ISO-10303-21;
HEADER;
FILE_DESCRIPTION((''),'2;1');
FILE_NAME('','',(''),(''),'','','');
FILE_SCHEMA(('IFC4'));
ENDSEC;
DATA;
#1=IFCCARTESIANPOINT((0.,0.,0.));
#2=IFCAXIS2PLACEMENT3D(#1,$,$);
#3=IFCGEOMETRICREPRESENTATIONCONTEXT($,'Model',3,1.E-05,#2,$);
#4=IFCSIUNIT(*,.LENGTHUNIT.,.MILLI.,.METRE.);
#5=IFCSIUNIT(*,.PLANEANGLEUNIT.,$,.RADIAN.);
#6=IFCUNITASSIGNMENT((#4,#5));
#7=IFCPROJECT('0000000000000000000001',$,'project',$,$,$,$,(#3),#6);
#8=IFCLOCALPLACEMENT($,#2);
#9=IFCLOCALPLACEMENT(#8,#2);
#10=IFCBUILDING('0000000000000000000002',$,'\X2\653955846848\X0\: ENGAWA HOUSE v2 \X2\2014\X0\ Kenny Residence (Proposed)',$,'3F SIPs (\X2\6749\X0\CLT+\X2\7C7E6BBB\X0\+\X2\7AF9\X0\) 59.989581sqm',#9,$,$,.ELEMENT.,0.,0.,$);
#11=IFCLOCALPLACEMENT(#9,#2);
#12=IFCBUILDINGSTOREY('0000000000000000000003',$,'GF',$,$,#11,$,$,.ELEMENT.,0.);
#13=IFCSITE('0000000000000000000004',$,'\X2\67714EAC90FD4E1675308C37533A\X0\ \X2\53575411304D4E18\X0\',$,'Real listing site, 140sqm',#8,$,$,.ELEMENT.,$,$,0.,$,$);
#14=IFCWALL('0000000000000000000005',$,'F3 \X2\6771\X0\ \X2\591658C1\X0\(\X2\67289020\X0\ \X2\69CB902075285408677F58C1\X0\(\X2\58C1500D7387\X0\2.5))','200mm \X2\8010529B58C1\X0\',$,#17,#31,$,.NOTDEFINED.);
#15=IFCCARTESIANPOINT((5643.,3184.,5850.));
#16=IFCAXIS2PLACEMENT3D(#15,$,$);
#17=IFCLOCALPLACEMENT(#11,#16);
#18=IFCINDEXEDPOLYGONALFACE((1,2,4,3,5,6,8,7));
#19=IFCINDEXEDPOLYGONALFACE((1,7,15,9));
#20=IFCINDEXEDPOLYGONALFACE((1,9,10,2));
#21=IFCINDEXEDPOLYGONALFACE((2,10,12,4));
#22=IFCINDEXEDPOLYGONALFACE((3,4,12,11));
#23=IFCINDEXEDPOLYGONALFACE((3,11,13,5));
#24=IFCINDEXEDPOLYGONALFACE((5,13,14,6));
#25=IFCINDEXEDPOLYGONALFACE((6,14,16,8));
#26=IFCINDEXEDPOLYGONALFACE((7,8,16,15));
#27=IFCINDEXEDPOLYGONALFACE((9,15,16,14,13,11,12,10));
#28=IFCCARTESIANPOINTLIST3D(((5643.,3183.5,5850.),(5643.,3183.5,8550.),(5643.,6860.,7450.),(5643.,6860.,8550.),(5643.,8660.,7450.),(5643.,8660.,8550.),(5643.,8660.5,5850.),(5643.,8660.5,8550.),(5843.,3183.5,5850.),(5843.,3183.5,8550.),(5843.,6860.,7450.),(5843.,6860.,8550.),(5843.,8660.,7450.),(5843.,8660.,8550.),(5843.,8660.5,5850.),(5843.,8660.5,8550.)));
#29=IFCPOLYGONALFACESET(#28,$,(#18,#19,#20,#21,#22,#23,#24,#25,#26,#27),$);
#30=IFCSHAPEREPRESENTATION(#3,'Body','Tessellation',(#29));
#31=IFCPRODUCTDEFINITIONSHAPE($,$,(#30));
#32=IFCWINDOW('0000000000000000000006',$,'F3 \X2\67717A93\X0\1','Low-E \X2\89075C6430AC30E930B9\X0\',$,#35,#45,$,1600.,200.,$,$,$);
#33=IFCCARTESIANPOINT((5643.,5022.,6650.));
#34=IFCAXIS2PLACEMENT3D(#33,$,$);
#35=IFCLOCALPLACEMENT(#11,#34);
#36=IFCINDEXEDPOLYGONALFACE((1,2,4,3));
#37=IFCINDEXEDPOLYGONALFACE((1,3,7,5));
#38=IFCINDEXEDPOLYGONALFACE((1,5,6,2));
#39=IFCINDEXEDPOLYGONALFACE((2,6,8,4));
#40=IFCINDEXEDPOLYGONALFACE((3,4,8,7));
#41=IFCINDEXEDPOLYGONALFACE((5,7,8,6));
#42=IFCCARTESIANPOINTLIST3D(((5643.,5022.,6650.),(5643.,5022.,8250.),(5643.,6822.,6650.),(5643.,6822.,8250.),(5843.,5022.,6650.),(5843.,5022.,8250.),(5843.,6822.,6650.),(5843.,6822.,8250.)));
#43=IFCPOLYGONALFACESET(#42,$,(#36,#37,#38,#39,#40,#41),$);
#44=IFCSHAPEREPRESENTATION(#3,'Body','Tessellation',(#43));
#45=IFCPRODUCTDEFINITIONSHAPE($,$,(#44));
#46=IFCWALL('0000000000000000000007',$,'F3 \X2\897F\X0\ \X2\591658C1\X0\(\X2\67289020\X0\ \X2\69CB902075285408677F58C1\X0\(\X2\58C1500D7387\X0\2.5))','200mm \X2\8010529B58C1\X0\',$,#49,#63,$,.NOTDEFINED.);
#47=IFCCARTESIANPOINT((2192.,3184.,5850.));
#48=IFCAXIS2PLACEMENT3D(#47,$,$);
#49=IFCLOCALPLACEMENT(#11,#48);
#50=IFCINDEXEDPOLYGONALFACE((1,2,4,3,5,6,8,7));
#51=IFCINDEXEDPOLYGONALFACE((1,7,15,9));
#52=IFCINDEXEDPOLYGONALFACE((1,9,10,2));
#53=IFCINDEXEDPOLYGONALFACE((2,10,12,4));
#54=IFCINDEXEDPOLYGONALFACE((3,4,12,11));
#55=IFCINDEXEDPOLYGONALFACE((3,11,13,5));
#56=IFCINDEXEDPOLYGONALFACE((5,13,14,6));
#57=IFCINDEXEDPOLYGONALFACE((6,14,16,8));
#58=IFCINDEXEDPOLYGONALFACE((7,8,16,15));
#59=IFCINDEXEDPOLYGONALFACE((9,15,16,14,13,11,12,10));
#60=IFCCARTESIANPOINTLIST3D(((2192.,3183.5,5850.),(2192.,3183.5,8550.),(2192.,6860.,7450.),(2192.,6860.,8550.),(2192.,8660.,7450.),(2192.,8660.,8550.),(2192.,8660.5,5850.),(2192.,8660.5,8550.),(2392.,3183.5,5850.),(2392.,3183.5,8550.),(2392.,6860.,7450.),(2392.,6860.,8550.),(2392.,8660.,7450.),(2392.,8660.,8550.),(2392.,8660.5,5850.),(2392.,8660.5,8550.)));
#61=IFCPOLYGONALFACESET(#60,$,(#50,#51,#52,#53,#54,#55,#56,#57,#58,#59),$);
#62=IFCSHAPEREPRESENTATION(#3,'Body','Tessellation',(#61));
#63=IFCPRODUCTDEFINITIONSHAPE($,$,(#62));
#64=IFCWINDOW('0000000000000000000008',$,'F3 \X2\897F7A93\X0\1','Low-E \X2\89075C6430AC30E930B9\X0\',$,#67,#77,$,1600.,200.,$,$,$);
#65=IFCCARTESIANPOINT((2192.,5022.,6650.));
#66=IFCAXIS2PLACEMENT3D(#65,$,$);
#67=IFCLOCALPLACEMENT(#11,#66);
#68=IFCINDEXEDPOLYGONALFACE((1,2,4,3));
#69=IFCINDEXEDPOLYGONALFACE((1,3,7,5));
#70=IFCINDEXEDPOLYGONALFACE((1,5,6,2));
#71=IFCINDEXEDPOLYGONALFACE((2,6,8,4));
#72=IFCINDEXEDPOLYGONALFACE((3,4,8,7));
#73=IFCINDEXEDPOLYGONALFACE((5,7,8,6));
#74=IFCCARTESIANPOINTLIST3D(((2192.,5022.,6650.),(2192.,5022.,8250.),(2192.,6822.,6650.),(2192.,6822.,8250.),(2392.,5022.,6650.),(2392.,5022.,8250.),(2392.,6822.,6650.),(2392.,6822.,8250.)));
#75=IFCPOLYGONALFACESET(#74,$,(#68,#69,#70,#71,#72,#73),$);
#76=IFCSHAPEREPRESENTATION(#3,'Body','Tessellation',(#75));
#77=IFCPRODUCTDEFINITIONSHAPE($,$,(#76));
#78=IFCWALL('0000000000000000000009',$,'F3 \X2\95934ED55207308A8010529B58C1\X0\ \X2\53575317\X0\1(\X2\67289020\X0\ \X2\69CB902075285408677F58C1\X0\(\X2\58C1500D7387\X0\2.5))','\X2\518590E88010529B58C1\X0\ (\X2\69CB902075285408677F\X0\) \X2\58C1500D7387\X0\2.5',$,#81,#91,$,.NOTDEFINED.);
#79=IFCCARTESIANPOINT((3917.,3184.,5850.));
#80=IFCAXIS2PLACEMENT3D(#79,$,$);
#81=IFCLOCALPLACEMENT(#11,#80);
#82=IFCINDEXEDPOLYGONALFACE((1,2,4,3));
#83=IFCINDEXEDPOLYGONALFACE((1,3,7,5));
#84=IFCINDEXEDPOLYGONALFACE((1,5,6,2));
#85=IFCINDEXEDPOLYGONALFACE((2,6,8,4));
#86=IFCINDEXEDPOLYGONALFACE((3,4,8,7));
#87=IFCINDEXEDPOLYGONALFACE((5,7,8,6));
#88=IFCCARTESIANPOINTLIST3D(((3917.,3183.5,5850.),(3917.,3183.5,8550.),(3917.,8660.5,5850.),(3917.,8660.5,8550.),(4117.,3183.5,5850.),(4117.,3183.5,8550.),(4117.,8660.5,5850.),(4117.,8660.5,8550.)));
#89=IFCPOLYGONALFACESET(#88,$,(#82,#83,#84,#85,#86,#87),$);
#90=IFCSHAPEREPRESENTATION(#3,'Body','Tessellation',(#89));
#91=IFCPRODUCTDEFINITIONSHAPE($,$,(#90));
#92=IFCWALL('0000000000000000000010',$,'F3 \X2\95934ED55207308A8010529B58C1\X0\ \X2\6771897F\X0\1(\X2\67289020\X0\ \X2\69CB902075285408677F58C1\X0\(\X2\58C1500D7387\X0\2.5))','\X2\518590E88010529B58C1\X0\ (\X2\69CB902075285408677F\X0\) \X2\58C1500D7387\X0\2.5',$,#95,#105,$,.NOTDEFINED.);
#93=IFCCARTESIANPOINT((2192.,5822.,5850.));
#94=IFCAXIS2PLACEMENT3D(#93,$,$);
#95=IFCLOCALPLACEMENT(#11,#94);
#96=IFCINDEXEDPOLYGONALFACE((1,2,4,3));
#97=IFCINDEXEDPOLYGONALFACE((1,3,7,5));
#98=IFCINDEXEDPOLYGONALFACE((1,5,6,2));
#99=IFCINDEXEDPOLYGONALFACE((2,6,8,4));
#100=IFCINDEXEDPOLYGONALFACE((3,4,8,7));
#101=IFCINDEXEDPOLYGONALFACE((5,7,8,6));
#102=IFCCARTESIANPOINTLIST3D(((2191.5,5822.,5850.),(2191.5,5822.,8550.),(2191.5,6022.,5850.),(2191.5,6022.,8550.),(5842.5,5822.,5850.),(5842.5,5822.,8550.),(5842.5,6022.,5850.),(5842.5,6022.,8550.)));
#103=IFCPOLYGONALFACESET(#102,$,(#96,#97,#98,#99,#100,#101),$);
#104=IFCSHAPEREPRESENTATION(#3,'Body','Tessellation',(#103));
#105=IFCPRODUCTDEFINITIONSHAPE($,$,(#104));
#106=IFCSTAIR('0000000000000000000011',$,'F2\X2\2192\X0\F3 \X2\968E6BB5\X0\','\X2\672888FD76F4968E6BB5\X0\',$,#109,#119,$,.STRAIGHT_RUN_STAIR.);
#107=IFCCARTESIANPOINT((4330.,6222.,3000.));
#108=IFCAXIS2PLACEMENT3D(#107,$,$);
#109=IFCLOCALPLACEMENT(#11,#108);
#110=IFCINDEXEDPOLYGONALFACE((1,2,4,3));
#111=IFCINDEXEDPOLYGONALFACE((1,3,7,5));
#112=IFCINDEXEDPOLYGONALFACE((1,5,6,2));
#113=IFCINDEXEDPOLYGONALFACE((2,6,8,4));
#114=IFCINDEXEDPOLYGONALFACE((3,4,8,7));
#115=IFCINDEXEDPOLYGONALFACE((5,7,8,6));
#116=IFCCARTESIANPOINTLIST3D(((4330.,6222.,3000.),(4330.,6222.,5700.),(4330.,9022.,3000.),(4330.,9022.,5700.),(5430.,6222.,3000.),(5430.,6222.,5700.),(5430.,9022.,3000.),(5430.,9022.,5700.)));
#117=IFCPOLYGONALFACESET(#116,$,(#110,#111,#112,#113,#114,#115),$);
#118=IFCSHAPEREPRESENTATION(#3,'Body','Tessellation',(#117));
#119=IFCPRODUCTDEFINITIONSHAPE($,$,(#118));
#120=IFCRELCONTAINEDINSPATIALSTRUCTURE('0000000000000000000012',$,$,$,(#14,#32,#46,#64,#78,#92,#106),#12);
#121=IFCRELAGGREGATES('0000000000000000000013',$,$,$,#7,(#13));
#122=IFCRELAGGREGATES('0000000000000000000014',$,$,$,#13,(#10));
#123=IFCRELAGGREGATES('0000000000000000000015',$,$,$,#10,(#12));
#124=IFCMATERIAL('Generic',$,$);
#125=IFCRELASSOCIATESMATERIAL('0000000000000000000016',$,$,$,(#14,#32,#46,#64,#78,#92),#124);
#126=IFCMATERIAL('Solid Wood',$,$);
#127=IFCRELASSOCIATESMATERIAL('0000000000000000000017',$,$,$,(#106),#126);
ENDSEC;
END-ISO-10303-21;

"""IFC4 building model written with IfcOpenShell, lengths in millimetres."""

from ifc_helpers import new_model, si_unit, frame, frame_2d, origin, place, context, project, spatial, rectangle, extrude, material, element, fill, save


model = new_model("IFC4")

# Units and contexts
model_context = context("Model", 3, precision=1e-05, world=origin())
ifc_project = project(units=[si_unit("LENGTHUNIT", "METRE", prefix="MILLI"), si_unit("PLANEANGLEUNIT", "RADIAN")], contexts=[model_context])

# Site, building, storey
site_placement = place(None, origin())
site = spatial("IfcSite", under=ifc_project, at=site_placement, Name="東京都世田谷区 南向き丘", ObjectType="Real listing site, 140sqm", CompositionType="ELEMENT", RefElevation=0.0)
building_placement = place(site_placement, origin())
building = spatial("IfcBuilding", under=site, at=building_placement, Name="改善案: ENGAWA HOUSE v2 — Kenny Residence (Proposed)", ObjectType="3F SIPs (杉CLT+籾殻+竹) 59.989581sqm", CompositionType="ELEMENT", ElevationOfRefHeight=0.0, ElevationOfTerrain=0.0)
storey_placement = place(building_placement, origin())
storey = spatial("IfcBuildingStorey", under=building, at=storey_placement, Name="GF", CompositionType="ELEMENT", Elevation=0.0)

# Shared definitions
ifc_material_1 = material(Name="Generic")

# Walls, openings, windows
wall_1_placement = place(storey_placement, frame((5643.0, 3184.0, 5850.0)))
wall_1 = element("IfcWall", 1, at=wall_1_placement, inside=storey, material=ifc_material_1, Name="F3 東 外壁(木造 構造用合板壁(壁倍率2.5))", Description="200mm 耐力壁", PredefinedType="NOTDEFINED", context=model_context, shape_type="SweptSolid", body=[
    extrude(rectangle(XDim=200.0, YDim=5477.0, at=frame_2d((100.0, 2738.0))), frame((5643.0, 3184.0, 5850.0)), (0.0, 0.0, 1.0), 2700.0),
])
opening_1_placement = place(storey_placement, frame((5643.0, 5022.0, 6650.0)))
opening_1 = element("IfcOpeningElement", 2, at=opening_1_placement, cuts=wall_1, PredefinedType="NOTDEFINED", context=model_context, shape_type="SweptSolid", body=[
    extrude(rectangle(XDim=200.0, YDim=1800.0, at=frame_2d((100.0, 900.0))), frame((5643.0, 5022.0, 6650.0)), (0.0, 0.0, 1.0), 1600.0),
])
window_1_placement = place(storey_placement, frame((5643.0, 5022.0, 6650.0)))
window_1 = element("IfcWindow", 3, at=window_1_placement, inside=storey, material=ifc_material_1, Name="F3 東窓1", Description="Low-E 複層ガラス", OverallHeight=1600.0, OverallWidth=200.0, context=model_context, shape_type="SweptSolid", body=[
    extrude(rectangle(XDim=200.0, YDim=1800.0, at=frame_2d((100.0, 900.0))), frame((5643.0, 5022.0, 6650.0)), (0.0, 0.0, 1.0), 1600.0),
])
fill(opening_1, window_1)
wall_2_placement = place(storey_placement, frame((2192.0, 3184.0, 5850.0)))
wall_2 = element("IfcWall", 4, at=wall_2_placement, inside=storey, material=ifc_material_1, Name="F3 西 外壁(木造 構造用合板壁(壁倍率2.5))", Description="200mm 耐力壁", PredefinedType="NOTDEFINED", context=model_context, shape_type="SweptSolid", body=[
    extrude(rectangle(XDim=200.0, YDim=5477.0, at=frame_2d((100.0, 2738.0))), frame((2192.0, 3184.0, 5850.0)), (0.0, 0.0, 1.0), 2700.0),
])
opening_2_placement = place(storey_placement, frame((2192.0, 5022.0, 6650.0)))
opening_2 = element("IfcOpeningElement", 5, at=opening_2_placement, cuts=wall_2, PredefinedType="NOTDEFINED", context=model_context, shape_type="SweptSolid", body=[
    extrude(rectangle(XDim=200.0, YDim=1800.0, at=frame_2d((100.0, 900.0))), frame((2192.0, 5022.0, 6650.0)), (0.0, 0.0, 1.0), 1600.0),
])
window_2_placement = place(storey_placement, frame((2192.0, 5022.0, 6650.0)))
window_2 = element("IfcWindow", 6, at=window_2_placement, inside=storey, material=ifc_material_1, Name="F3 西窓1", Description="Low-E 複層ガラス", OverallHeight=1600.0, OverallWidth=200.0, context=model_context, shape_type="SweptSolid", body=[
    extrude(rectangle(XDim=200.0, YDim=1800.0, at=frame_2d((100.0, 900.0))), frame((2192.0, 5022.0, 6650.0)), (0.0, 0.0, 1.0), 1600.0),
])
fill(opening_2, window_2)

# Walls
wall_3_placement = place(storey_placement, frame((3917.0, 3184.0, 5850.0)))
element("IfcWall", 7, at=wall_3_placement, inside=storey, material=ifc_material_1, Name="F3 間仕切り耐力壁 南北1(木造 構造用合板壁(壁倍率2.5))", Description="内部耐力壁 (構造用合板) 壁倍率2.5", PredefinedType="NOTDEFINED", context=model_context, shape_type="SweptSolid", body=[
    extrude(rectangle(XDim=200.0, YDim=5477.0, at=frame_2d((100.0, 2738.0))), frame((3917.0, 3184.0, 5850.0)), (0.0, 0.0, 1.0), 2700.0),
])
wall_4_placement = place(storey_placement, frame((2192.0, 5822.0, 5850.0)))
element("IfcWall", 8, at=wall_4_placement, inside=storey, material=ifc_material_1, Name="F3 間仕切り耐力壁 東西1(木造 構造用合板壁(壁倍率2.5))", Description="内部耐力壁 (構造用合板) 壁倍率2.5", PredefinedType="NOTDEFINED", context=model_context, shape_type="SweptSolid", body=[
    extrude(rectangle(XDim=3651.0, YDim=200.0, at=frame_2d((1825.0, 100.0))), frame((2192.0, 5822.0, 5850.0)), (0.0, 0.0, 1.0), 2700.0),
])

# Stair
ifc_material_2 = material(Name="Solid Wood")
stair_placement = place(storey_placement, frame((4330.0, 6222.0, 3000.0)))
element("IfcStair", 9, at=stair_placement, inside=storey, material=ifc_material_2, Name="F2→F3 階段", Description="木製直階段", PredefinedType="STRAIGHT_RUN_STAIR", context=model_context, shape_type="SweptSolid", body=[
    extrude(rectangle(XDim=1100.0, YDim=2800.0, at=frame_2d((550.0, 1400.0))), frame((4330.0, 6222.0, 3000.0)), (0.0, 0.0, 1.0), 2700.0),
])

save(model, "model.ifc")
